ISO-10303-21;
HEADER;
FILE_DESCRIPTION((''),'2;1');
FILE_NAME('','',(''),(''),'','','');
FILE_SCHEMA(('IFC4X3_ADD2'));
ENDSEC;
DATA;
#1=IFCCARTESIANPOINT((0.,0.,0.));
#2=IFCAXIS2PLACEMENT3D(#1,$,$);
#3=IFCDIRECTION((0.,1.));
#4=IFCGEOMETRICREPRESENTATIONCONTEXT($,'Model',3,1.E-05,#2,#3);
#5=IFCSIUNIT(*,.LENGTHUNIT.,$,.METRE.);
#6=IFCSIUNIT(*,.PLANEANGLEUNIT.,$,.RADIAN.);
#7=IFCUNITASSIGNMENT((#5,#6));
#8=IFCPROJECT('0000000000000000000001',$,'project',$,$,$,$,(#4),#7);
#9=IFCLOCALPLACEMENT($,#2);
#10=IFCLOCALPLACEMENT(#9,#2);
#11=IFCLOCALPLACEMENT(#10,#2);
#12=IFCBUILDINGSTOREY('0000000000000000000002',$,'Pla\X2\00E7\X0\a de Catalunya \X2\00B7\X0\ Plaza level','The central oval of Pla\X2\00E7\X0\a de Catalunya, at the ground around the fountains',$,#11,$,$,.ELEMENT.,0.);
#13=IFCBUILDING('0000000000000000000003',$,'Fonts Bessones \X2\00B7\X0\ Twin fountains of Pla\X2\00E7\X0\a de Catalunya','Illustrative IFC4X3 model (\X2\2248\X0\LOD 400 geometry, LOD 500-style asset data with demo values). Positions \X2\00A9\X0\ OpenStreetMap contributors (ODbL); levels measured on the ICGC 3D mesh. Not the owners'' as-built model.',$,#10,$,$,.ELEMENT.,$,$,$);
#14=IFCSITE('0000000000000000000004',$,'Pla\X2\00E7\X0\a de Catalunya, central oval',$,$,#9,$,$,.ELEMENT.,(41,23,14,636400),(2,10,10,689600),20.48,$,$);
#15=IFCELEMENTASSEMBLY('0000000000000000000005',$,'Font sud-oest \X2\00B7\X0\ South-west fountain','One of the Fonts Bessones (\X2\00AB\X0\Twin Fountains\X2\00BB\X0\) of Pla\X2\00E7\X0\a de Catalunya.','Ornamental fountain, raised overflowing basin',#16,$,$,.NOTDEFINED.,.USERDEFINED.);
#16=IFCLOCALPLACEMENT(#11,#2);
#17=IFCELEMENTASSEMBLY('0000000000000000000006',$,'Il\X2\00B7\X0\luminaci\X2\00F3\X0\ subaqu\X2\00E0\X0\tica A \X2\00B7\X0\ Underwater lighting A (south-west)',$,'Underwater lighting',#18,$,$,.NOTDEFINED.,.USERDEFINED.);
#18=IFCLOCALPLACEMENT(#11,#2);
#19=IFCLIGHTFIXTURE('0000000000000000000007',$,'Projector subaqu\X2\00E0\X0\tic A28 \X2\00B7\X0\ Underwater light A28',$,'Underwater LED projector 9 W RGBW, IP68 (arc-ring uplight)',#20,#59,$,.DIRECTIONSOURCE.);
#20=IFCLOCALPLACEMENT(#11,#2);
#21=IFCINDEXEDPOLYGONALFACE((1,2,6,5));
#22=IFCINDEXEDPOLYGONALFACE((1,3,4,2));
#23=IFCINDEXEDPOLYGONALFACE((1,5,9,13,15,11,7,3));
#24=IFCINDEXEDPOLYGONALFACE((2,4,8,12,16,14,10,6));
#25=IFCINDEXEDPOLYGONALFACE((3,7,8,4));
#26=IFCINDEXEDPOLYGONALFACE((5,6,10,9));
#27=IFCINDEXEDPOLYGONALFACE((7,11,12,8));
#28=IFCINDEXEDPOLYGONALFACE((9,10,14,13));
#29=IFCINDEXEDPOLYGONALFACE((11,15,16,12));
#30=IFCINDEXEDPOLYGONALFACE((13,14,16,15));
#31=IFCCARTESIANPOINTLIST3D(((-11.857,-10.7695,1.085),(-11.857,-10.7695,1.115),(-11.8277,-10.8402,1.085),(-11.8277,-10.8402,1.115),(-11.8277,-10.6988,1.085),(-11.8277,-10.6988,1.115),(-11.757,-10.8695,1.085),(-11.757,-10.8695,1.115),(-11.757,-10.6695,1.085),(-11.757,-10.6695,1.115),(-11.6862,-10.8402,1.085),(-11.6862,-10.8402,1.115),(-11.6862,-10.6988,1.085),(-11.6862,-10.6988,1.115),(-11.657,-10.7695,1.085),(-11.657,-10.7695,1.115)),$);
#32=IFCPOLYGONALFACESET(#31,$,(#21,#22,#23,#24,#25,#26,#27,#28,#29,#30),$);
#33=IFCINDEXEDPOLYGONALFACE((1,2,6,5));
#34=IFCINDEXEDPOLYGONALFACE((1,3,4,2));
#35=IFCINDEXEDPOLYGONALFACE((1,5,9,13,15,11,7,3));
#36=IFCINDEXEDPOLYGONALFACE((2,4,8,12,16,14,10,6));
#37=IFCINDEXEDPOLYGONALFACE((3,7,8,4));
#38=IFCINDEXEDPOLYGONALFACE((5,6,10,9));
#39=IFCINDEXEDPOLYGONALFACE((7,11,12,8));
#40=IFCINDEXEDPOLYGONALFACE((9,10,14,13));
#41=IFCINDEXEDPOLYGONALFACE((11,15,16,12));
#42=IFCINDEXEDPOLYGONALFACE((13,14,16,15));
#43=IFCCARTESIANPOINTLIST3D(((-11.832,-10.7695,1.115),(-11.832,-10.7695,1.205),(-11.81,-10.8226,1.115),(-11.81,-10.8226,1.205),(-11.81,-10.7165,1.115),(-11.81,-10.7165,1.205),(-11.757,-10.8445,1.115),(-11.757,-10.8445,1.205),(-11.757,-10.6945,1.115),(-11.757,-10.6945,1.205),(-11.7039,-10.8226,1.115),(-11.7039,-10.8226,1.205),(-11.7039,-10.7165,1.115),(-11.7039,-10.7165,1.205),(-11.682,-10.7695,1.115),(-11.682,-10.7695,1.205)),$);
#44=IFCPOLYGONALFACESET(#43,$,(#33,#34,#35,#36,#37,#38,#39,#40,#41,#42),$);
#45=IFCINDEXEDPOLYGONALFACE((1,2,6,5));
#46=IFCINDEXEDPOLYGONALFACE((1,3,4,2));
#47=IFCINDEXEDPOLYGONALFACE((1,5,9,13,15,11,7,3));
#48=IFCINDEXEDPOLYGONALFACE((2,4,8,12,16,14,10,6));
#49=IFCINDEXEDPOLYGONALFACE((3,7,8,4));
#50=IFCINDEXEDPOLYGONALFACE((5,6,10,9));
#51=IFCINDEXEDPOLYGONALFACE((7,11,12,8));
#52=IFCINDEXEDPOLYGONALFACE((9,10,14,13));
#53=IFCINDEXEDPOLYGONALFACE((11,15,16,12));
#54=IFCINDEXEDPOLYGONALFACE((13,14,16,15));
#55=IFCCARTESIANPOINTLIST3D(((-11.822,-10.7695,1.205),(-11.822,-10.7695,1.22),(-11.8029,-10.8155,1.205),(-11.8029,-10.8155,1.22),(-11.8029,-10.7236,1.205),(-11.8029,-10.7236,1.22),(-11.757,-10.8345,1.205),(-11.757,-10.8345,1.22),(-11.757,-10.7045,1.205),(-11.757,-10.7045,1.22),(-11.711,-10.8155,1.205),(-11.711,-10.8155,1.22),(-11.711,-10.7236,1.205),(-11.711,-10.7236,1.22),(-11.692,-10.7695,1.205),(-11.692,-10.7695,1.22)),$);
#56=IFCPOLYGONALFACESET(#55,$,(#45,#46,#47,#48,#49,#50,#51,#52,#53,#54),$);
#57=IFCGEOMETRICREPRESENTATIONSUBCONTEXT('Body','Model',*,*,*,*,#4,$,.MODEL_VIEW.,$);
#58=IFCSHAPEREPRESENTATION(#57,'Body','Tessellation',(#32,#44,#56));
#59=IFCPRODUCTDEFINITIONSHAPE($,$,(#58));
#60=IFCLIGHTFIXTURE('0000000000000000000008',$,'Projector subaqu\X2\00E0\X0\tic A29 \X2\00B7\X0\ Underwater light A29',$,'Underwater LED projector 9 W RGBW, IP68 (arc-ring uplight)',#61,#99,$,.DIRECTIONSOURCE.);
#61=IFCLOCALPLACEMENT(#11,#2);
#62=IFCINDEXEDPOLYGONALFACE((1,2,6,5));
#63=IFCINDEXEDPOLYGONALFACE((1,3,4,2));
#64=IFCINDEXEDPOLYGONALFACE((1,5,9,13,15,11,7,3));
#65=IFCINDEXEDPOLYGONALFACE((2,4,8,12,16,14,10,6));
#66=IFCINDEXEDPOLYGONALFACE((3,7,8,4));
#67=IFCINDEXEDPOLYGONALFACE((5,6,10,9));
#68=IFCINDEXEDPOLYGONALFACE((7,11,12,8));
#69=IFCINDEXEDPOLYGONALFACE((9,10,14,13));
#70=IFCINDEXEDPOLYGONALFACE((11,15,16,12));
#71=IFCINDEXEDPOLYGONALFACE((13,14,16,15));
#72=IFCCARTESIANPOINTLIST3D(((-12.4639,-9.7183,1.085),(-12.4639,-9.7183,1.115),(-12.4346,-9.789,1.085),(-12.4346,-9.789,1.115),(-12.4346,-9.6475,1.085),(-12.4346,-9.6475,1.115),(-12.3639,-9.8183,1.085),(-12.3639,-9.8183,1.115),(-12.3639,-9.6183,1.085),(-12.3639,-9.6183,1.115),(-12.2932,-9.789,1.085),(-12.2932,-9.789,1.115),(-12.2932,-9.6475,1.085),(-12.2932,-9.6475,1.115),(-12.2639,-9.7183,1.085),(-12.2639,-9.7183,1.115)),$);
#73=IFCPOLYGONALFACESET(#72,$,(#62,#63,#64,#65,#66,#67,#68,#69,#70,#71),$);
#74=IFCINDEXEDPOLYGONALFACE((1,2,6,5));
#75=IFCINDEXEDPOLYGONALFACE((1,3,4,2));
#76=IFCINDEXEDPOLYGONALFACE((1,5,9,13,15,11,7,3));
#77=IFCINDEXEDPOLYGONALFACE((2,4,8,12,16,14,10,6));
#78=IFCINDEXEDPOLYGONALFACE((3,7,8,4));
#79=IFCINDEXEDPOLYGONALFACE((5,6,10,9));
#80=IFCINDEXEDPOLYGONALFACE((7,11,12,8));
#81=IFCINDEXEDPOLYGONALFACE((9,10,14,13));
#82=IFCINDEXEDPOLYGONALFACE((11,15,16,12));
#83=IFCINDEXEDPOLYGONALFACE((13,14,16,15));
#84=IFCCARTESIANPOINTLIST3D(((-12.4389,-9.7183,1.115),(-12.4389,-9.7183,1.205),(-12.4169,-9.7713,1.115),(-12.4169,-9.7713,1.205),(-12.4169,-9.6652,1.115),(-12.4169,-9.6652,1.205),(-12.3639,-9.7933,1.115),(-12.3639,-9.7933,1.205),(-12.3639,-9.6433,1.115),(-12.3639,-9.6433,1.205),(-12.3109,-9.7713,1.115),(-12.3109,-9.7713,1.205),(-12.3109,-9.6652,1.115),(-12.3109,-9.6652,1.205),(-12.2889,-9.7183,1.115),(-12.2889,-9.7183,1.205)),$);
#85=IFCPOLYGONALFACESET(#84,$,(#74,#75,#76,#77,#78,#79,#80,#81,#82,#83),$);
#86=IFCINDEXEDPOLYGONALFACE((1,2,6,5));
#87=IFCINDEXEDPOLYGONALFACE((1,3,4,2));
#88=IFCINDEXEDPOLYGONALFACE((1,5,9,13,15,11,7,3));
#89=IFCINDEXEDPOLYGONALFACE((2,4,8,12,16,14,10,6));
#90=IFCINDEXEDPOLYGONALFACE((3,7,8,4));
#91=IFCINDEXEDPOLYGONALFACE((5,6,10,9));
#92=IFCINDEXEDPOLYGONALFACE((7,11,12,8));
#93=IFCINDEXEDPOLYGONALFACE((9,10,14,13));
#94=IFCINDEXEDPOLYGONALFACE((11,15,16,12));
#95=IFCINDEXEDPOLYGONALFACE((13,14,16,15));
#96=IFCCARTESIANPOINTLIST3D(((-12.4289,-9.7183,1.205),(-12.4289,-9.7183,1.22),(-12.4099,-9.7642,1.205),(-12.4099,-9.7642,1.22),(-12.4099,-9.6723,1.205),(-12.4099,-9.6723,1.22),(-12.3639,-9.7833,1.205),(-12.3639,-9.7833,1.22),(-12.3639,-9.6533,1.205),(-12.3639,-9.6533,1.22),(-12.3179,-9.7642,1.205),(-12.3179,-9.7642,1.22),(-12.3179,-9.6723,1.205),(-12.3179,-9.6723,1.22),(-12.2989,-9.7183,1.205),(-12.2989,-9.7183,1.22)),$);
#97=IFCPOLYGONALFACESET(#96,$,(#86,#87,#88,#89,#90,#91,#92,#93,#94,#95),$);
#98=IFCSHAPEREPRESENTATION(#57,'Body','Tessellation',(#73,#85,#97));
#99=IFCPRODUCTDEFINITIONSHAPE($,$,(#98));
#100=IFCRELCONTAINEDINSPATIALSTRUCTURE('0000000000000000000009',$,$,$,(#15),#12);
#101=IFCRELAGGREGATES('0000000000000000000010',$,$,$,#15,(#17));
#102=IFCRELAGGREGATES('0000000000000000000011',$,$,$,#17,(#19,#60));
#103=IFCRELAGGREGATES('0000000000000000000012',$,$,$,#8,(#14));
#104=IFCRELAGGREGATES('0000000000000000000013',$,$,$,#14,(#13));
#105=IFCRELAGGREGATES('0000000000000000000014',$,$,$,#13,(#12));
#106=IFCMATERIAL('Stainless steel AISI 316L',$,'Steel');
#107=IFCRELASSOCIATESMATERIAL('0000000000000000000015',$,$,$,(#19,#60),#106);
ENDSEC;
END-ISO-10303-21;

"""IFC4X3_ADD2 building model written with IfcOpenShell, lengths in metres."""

from ifc_helpers import new_model, si_unit, direction, frame, origin, place, context, subcontext, project, spatial, polyline, outline, extrude, material, element, aggregate, save


model = new_model("IFC4X3_ADD2")

# Units and contexts
model_context = context("Model", 3, precision=1e-05, world=origin(), true_north=direction((0.0, 1.0)))
body_context = subcontext(model_context, "Body", "Model", "MODEL_VIEW")
ifc_project = project(units=[si_unit("LENGTHUNIT", "METRE"), si_unit("PLANEANGLEUNIT", "RADIAN")], contexts=[model_context])

# Site, building, storey
site_placement = place(None, origin())
site = spatial("IfcSite", under=ifc_project, at=site_placement, Name="Plaça de Catalunya, central oval", CompositionType="ELEMENT", RefLatitude=(41, 23, 14, 636400), RefLongitude=(2, 10, 10, 689600), RefElevation=20.48)
building_placement = place(site_placement, origin())
building = spatial("IfcBuilding", under=site, at=building_placement, Name="Fonts Bessones · Twin fountains of Plaça de Catalunya", Description="Illustrative IFC4X3 model (≈LOD 400 geometry, LOD 500-style asset data with demo values). Positions © OpenStreetMap contributors (ODbL); levels measured on the ICGC 3D mesh. Not the owners' as-built model.", CompositionType="ELEMENT")
storey_placement = place(building_placement, origin())
storey = spatial("IfcBuildingStorey", under=building, at=storey_placement, Name="Plaça de Catalunya · Plaza level", Description="The central oval of Plaça de Catalunya, at the ground around the fountains", CompositionType="ELEMENT", Elevation=0.0)

# Element assemblies, light fixtures
assembly_1_placement = place(building_placement, origin())
assembly_1 = element("IfcElementAssembly", 1, at=assembly_1_placement, inside=storey, Name="Font sud-oest · South-west fountain", Description="One of the Fonts Bessones («Twin Fountains») of Plaça de Catalunya.", ObjectType="Ornamental fountain, raised overflowing basin", AssemblyPlace="NOTDEFINED", PredefinedType="USERDEFINED")
assembly_2_placement = place(building_placement, origin())
assembly_2 = element("IfcElementAssembly", 2, at=assembly_2_placement, Name="Il·luminació subaquàtica A · Underwater lighting A (south-west)", ObjectType="Underwater lighting", AssemblyPlace="NOTDEFINED", PredefinedType="USERDEFINED")
aggregate(assembly_1, [assembly_2])
ifc_material_1 = material(Name="Stainless steel AISI 316L", Category="Steel")
light_fixture_1_placement = place(building_placement, origin())
light_fixture_1 = element("IfcLightFixture", 3, at=light_fixture_1_placement, material=ifc_material_1, Name="Projector subaquàtic A28 · Underwater light A28", ObjectType="Underwater LED projector 9 W RGBW, IP68 (arc-ring uplight)", PredefinedType="DIRECTIONSOURCE", context=body_context, shape_type="SweptSolid", body=[
    extrude(outline(polyline([(-11.657, -10.7695), (-11.6862, -10.6988), (-11.757, -10.6695), (-11.8277, -10.6988), (-11.857, -10.7695), (-11.8277, -10.8402), (-11.757, -10.8695), (-11.6862, -10.8402), (-11.657, -10.7695)])), frame((0.0, 0.0, 1.085)), (0.0, 0.0, 1.0), 0.03),
    extrude(outline(polyline([(-11.682, -10.7695), (-11.7039, -10.7165), (-11.757, -10.6945), (-11.81, -10.7165), (-11.832, -10.7695), (-11.81, -10.8226), (-11.757, -10.8445), (-11.7039, -10.8226), (-11.682, -10.7695)])), frame((0.0, 0.0, 1.115)), (0.0, 0.0, 1.0), 0.09),
    extrude(outline(polyline([(-11.692, -10.7695), (-11.711, -10.7236), (-11.757, -10.7045), (-11.8029, -10.7236), (-11.822, -10.7695), (-11.8029, -10.8155), (-11.757, -10.8345), (-11.711, -10.8155), (-11.692, -10.7695)])), frame((0.0, 0.0, 1.205)), (0.0, 0.0, 1.0), 0.015),
])
light_fixture_2_placement = place(building_placement, origin())
light_fixture_2 = element("IfcLightFixture", 4, at=light_fixture_2_placement, material=ifc_material_1, Name="Projector subaquàtic A29 · Underwater light A29", ObjectType="Underwater LED projector 9 W RGBW, IP68 (arc-ring uplight)", PredefinedType="DIRECTIONSOURCE", context=body_context, shape_type="SweptSolid", body=[
    extrude(outline(polyline([(-12.2639, -9.7183), (-12.2932, -9.6475), (-12.3639, -9.6183), (-12.4346, -9.6475), (-12.4639, -9.7183), (-12.4346, -9.789), (-12.3639, -9.8183), (-12.2932, -9.789), (-12.2639, -9.7183)])), frame((0.0, 0.0, 1.085)), (0.0, 0.0, 1.0), 0.03),
    extrude(outline(polyline([(-12.2889, -9.7183), (-12.3109, -9.6652), (-12.3639, -9.6433), (-12.4169, -9.6652), (-12.4389, -9.7183), (-12.4169, -9.7713), (-12.3639, -9.7933), (-12.3109, -9.7713), (-12.2889, -9.7183)])), frame((0.0, 0.0, 1.115)), (0.0, 0.0, 1.0), 0.09),
    extrude(outline(polyline([(-12.2989, -9.7183), (-12.3179, -9.6723), (-12.3639, -9.6533), (-12.4099, -9.6723), (-12.4289, -9.7183), (-12.4099, -9.7642), (-12.3639, -9.7833), (-12.3179, -9.7642), (-12.2989, -9.7183)])), frame((0.0, 0.0, 1.205)), (0.0, 0.0, 1.0), 0.015),
])
aggregate(assembly_2, [light_fixture_1, light_fixture_2])

save(model, "model.ifc")
